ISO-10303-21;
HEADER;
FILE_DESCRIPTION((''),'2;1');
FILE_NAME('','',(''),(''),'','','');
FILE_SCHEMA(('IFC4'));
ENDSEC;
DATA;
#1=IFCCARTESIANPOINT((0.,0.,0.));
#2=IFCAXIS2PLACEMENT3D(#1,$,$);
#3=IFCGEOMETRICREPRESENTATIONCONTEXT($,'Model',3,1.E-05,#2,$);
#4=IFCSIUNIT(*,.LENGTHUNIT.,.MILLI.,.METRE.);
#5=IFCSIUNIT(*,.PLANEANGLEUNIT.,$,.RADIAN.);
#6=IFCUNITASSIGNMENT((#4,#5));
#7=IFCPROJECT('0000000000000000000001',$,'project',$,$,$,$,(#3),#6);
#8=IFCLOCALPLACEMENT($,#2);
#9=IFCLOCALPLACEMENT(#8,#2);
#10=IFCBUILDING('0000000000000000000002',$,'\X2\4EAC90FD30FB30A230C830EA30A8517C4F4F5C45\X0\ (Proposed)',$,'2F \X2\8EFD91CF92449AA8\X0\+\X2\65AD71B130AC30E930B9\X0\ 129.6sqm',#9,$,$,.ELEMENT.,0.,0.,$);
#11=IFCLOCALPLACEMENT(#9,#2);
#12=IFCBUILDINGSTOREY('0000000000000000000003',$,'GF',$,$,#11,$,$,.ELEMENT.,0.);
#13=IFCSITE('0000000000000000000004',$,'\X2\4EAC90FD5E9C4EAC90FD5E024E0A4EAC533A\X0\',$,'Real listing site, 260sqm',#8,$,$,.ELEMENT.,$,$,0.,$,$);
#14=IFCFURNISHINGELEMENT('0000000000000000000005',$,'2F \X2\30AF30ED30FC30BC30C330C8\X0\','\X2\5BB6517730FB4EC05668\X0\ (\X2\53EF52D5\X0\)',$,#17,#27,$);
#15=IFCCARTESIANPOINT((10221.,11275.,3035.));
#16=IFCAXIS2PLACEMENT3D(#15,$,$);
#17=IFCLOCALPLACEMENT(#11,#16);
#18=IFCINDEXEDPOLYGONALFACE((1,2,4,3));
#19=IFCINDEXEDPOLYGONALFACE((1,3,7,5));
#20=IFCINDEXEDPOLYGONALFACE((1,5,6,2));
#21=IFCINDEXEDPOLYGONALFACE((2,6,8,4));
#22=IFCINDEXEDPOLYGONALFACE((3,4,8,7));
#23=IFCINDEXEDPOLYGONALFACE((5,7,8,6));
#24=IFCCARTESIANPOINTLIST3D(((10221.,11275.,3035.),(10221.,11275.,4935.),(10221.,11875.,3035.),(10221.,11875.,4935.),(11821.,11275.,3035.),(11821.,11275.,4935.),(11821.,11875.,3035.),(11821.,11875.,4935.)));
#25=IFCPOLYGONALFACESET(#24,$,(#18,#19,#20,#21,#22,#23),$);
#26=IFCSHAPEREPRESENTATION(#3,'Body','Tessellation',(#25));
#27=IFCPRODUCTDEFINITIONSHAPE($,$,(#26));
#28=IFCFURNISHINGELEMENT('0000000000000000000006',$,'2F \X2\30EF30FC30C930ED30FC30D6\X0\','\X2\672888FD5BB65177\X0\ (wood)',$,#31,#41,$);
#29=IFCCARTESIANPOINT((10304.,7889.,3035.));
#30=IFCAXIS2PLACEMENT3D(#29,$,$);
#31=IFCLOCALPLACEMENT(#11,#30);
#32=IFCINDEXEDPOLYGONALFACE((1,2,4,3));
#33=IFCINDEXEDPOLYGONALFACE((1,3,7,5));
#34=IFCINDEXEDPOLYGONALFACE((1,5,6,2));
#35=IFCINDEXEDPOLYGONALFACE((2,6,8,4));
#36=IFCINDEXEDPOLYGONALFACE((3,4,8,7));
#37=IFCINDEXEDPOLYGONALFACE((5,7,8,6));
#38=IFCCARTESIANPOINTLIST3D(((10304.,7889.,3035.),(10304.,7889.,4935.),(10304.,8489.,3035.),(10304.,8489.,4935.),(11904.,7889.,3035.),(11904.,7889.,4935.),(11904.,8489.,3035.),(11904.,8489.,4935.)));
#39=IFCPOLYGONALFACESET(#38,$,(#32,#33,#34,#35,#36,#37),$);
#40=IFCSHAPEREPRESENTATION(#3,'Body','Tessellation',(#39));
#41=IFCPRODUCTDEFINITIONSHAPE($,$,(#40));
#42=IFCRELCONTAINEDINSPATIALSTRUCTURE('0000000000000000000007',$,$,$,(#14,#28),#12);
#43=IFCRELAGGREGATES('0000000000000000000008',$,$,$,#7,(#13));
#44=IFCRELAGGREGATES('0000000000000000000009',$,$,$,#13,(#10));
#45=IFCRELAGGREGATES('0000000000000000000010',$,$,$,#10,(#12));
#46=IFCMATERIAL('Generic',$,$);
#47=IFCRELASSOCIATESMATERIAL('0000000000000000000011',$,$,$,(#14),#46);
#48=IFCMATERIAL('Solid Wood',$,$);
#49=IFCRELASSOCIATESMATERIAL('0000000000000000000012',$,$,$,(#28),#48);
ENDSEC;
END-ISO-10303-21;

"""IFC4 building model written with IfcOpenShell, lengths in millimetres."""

from ifc_helpers import new_model, si_unit, frame, frame_2d, origin, place, context, project, spatial, rectangle, extrude, material, element, save


model = new_model("IFC4")

# Units and contexts
model_context = context("Model", 3, precision=1e-05, world=origin())
ifc_project = project(units=[si_unit("LENGTHUNIT", "METRE", prefix="MILLI"), si_unit("PLANEANGLEUNIT", "RADIAN")], contexts=[model_context])

# Site, building, storey
site_placement = place(None, origin())
site = spatial("IfcSite", under=ifc_project, at=site_placement, Name="京都府京都市上京区", ObjectType="Real listing site, 260sqm", CompositionType="ELEMENT", RefElevation=0.0)
building_placement = place(site_placement, origin())
building = spatial("IfcBuilding", under=site, at=building_placement, Name="京都・アトリエ兼住居 (Proposed)", ObjectType="2F 軽量鉄骨+断熱ガラス 129.6sqm", CompositionType="ELEMENT", ElevationOfRefHeight=0.0, ElevationOfTerrain=0.0)
storey_placement = place(building_placement, origin())
storey = spatial("IfcBuildingStorey", under=building, at=storey_placement, Name="GF", CompositionType="ELEMENT", Elevation=0.0)

# Shared definitions
ifc_material_1 = material(Name="Solid Wood")

# Shared definitions
ifc_material_2 = material(Name="Generic")

# Furnishing elements
furnishing_1_placement = place(storey_placement, frame((10221.0, 11275.0, 3035.0)))
element("IfcFurnishingElement", 1, at=furnishing_1_placement, inside=storey, material=ifc_material_2, Name="2F クローゼット", Description="家具・什器 (可動)", context=model_context, shape_type="SweptSolid", body=[
    extrude(rectangle(XDim=1600.0, YDim=600.0, at=frame_2d((800.0, 300.0))), frame((10221.0, 11275.0, 3035.0)), (0.0, 0.0, 1.0), 1900.0),
])
furnishing_2_placement = place(storey_placement, frame((10304.0, 7889.0, 3035.0)))
element("IfcFurnishingElement", 2, at=furnishing_2_placement, inside=storey, material=ifc_material_1, Name="2F ワードローブ", Description="木製家具 (wood)", context=model_context, shape_type="SweptSolid", body=[
    extrude(rectangle(XDim=1600.0, YDim=600.0, at=frame_2d((800.0, 300.0))), frame((10304.0, 7889.0, 3035.0)), (0.0, 0.0, 1.0), 1900.0),
])

save(model, "model.ifc")
